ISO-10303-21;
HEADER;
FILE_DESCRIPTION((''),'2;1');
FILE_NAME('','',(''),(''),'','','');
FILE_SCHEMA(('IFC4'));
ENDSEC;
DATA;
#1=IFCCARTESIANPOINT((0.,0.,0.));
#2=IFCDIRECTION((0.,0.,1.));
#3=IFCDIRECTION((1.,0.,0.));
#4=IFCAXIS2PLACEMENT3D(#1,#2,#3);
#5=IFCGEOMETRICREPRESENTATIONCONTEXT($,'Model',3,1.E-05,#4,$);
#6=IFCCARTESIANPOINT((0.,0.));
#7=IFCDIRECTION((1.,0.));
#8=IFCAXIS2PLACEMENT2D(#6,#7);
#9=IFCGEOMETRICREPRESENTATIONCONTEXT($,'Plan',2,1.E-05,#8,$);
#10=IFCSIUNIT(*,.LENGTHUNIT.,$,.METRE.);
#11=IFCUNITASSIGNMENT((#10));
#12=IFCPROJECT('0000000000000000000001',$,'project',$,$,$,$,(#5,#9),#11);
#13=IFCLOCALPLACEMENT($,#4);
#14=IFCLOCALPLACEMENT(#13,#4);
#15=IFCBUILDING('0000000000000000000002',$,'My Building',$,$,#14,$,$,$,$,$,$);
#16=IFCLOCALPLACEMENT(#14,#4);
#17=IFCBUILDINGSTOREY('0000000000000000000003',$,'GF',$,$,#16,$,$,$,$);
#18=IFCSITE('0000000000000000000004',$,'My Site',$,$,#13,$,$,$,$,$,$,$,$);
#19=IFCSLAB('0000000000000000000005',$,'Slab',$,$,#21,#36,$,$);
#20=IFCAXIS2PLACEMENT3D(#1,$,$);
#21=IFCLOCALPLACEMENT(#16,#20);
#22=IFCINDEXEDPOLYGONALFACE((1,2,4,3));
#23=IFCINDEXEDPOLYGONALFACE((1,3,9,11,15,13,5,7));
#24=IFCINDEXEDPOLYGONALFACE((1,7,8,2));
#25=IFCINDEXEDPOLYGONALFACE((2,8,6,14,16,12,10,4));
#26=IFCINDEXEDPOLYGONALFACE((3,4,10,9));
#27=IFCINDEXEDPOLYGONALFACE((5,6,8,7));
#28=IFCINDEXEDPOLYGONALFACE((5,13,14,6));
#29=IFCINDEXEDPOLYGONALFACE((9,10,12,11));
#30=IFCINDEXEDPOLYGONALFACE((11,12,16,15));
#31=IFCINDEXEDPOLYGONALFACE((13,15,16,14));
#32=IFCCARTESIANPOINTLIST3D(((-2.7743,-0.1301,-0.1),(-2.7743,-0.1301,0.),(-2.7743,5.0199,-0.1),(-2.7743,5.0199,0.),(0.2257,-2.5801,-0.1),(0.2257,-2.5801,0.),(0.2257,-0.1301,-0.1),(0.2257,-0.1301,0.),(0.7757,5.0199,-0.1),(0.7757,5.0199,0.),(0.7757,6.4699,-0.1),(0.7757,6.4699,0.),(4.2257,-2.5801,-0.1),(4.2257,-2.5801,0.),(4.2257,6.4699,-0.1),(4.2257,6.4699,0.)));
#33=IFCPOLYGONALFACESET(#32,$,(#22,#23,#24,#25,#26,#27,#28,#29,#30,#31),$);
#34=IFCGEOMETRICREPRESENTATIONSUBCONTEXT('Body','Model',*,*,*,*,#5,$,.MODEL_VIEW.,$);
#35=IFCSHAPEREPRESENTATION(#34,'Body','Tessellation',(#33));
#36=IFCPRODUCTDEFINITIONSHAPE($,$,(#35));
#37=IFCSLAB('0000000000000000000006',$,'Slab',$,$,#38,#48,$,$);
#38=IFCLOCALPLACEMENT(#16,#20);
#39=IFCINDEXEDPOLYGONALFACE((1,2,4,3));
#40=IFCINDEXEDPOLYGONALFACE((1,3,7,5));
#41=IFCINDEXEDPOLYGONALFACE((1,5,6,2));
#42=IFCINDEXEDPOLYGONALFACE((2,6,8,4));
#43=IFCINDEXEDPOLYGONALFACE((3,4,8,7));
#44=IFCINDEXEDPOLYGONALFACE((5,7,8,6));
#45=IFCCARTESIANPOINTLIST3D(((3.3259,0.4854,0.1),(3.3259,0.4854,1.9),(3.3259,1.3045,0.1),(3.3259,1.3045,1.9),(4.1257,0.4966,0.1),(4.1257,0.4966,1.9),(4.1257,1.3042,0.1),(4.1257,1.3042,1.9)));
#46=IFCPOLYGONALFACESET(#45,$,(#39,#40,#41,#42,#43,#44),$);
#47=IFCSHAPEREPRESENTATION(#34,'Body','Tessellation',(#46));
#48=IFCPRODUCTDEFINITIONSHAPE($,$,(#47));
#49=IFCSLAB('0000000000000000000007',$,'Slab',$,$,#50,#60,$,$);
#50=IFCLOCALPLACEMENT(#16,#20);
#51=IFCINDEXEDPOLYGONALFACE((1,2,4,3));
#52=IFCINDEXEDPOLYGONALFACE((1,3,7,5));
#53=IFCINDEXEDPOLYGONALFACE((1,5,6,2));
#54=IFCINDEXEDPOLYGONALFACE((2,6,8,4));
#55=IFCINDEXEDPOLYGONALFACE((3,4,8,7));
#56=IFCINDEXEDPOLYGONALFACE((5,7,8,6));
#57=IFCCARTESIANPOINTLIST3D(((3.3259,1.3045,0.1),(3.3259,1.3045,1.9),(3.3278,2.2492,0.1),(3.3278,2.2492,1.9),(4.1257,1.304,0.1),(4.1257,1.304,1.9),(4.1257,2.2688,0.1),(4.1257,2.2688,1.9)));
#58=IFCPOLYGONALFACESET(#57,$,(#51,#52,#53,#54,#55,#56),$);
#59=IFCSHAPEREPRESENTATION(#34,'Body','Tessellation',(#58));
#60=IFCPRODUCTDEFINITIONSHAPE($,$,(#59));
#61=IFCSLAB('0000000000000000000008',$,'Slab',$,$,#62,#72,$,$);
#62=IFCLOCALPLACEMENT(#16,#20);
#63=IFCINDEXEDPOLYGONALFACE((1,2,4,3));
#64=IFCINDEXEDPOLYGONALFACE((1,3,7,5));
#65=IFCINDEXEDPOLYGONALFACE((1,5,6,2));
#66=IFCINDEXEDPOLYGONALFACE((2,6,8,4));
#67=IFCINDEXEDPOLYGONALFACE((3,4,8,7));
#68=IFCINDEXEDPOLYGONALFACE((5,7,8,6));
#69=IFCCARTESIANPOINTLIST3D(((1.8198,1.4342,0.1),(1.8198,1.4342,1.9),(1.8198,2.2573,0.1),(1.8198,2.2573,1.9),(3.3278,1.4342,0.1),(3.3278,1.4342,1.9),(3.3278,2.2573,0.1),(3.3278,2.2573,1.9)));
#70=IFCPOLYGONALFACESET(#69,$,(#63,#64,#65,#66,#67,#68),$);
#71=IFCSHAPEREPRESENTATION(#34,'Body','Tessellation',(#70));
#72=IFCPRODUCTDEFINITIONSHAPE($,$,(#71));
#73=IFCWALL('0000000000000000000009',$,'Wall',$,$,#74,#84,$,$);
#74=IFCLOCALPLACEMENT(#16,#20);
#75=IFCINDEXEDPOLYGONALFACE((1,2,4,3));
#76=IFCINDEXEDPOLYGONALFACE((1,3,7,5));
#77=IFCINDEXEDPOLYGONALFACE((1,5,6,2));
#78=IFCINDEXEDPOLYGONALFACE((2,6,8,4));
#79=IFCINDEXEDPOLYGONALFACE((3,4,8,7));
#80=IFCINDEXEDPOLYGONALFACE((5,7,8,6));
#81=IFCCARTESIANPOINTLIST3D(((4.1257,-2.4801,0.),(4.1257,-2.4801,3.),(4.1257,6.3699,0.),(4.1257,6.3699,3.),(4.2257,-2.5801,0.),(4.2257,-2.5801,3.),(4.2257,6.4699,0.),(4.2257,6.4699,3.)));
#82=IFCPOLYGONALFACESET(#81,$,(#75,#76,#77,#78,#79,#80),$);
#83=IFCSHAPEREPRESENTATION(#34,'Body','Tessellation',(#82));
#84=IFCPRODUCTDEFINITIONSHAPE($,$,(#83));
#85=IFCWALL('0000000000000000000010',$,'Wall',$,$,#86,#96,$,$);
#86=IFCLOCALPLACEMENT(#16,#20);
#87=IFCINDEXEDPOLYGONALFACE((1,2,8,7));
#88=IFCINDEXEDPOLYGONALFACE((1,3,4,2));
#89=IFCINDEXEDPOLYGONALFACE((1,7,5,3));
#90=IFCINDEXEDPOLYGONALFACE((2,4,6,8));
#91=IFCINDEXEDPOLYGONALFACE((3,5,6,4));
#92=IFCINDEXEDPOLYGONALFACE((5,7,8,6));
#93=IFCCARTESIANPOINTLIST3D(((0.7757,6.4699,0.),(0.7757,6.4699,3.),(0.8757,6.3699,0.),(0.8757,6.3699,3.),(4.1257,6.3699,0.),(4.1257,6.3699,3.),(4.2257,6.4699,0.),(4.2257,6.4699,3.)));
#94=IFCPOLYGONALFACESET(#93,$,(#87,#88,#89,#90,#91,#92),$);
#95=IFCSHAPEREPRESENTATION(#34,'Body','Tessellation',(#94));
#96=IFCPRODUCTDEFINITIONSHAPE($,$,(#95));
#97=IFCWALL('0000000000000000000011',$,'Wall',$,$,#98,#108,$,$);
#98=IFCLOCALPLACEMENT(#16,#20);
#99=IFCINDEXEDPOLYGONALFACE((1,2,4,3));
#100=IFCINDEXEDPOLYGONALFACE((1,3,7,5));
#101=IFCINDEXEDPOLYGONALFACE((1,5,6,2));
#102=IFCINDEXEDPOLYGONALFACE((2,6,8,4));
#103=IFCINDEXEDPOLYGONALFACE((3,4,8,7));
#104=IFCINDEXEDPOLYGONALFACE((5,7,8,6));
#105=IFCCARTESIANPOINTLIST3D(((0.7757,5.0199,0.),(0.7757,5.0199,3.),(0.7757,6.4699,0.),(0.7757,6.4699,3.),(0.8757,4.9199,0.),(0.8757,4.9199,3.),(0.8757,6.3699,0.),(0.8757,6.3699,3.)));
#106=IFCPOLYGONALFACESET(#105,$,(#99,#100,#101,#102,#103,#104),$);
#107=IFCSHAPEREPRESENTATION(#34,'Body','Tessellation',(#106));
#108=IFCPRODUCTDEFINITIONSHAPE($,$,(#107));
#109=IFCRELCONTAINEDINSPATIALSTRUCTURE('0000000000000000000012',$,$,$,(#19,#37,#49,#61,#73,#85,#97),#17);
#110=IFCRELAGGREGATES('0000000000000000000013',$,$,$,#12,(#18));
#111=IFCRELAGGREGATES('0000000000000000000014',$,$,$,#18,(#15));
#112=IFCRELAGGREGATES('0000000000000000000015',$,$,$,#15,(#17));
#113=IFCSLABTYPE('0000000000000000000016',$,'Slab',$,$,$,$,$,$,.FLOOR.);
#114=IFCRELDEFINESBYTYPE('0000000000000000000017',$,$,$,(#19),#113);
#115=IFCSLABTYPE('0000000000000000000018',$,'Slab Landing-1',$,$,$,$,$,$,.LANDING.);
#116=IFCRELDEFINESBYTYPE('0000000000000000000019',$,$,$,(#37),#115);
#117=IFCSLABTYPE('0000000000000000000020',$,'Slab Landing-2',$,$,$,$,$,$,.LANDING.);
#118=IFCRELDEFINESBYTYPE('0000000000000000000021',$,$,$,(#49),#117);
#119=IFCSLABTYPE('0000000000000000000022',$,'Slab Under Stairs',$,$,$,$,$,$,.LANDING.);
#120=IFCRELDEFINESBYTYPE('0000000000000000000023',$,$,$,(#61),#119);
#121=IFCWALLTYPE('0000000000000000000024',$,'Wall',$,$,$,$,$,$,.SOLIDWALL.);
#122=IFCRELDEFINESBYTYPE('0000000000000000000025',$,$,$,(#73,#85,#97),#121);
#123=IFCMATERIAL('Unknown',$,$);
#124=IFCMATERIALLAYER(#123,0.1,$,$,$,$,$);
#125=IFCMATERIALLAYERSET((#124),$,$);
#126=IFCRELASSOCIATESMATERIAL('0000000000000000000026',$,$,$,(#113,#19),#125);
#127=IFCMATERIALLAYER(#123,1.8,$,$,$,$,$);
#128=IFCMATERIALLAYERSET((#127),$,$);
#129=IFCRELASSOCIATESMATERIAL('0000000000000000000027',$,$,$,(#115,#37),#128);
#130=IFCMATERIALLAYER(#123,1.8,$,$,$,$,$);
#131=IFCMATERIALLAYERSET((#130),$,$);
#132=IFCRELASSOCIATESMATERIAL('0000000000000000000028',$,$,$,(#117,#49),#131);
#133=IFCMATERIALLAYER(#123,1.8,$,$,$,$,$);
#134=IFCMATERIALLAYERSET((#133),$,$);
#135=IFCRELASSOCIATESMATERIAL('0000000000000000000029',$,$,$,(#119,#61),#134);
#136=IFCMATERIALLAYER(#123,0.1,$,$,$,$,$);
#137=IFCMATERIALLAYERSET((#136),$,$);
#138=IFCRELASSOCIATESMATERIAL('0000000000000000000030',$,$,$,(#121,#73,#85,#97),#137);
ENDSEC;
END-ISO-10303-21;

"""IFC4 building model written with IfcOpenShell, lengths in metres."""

from ifc_helpers import new_model, si_unit, frame, origin_with_axes, origin_2d_with_axis, place, context, subcontext, project, spatial, line, indexed_curve, outline, extrude, material, layer, layer_set, layer_usage, type_object, element, save


model = new_model("IFC4")

# Units and contexts
model_context = context("Model", 3, precision=1e-05, world=origin_with_axes())
plan_context = context("Plan", 2, precision=1e-05, world=origin_2d_with_axis())
body_context_1 = subcontext(model_context, "Body", "Model", "MODEL_VIEW")
ifc_project = project(units=[si_unit("LENGTHUNIT", "METRE")], contexts=[model_context, plan_context])

# Site, building, storey
site_placement = place(None, origin_with_axes())
site = spatial("IfcSite", under=ifc_project, at=site_placement, Name="My Site")
building_placement = place(site_placement, origin_with_axes())
building = spatial("IfcBuilding", under=site, at=building_placement, Name="My Building")
storey_placement = place(building_placement, origin_with_axes())
storey = spatial("IfcBuildingStorey", under=building, at=storey_placement, Name="GF")

# Slabs
ifc_material_1 = material(Name="Unknown")
ifc_layer_1 = layer(ifc_material_1, 0.1)
ifc_layer_set_1 = layer_set([ifc_layer_1])
ifc_layer_usage_1 = layer_usage(ifc_layer_set_1, "AXIS3", "POSITIVE", -0.1)
slab_type_1 = type_object("IfcSlabType", Name="Slab", PredefinedType="FLOOR", material=ifc_layer_set_1)
slab_1_placement = place(storey_placement, frame((4.2257, 6.4699, 0.0), z_axis=(0.0, 0.0, 1.0), x_axis=(1.0, 0.0, 0.0)))
element("IfcSlab", 1, at=slab_1_placement, inside=storey, type_object=slab_type_1, material=ifc_layer_usage_1, Name="Slab", context=body_context_1, shape_type="SweptSolid", body=[
    extrude(outline(indexed_curve([(0.0, 0.0), (-3.45, 0.0), (-3.45, -1.45), (-7.0, -1.45), (-7.0, -6.6), (-4.0, -6.6), (-4.0, -9.05), (0.0, -9.05), (0.0, 0.0)])), frame((0.0, 0.0, -0.1), z_axis=(0.0, 0.0, 1.0), x_axis=(1.0, 0.0, 0.0)), (0.0, 0.0, 1.0), 0.1),
])
ifc_layer_2 = layer(ifc_material_1, 1.8)
ifc_layer_set_2 = layer_set([ifc_layer_2])
ifc_layer_usage_2 = layer_usage(ifc_layer_set_2, "AXIS3", "POSITIVE", -0.1)
slab_type_2 = type_object("IfcSlabType", Name="Slab Landing-1", PredefinedType="LANDING", material=ifc_layer_set_2)
slab_2_placement = place(storey_placement, frame((3.3259, 1.3043, 0.2), z_axis=(0.0, 0.0, 1.0), x_axis=(1.0, 0.0, 0.0)))
element("IfcSlab", 2, at=slab_2_placement, inside=storey, type_object=slab_type_2, material=ifc_layer_usage_2, Name="Slab", context=body_context_1, shape_type="SweptSolid", body=[
    extrude(outline(indexed_curve([(0.7998, -0.0001), (0.7998, -0.8077), (0.0, -0.8189), (0.0, 0.0002), (0.7998, -0.0001)])), frame((0.0, 0.0, -0.1), z_axis=(0.0, 0.0, 1.0), x_axis=(1.0, 0.0, 0.0)), (0.0, 0.0, 1.0), 1.8),
])
ifc_layer_3 = layer(ifc_material_1, 1.8)
ifc_layer_set_3 = layer_set([ifc_layer_3])
ifc_layer_usage_3 = layer_usage(ifc_layer_set_3, "AXIS3", "POSITIVE", -1.8)
slab_type_3 = type_object("IfcSlabType", Name="Slab Landing-2", PredefinedType="LANDING", material=ifc_layer_set_3)
slab_3_placement = place(storey_placement, frame((3.3278, 1.3045, 1.9), z_axis=(0.0, 0.0, 1.0), x_axis=(1.0, 0.0, 0.0)))
element("IfcSlab", 3, at=slab_3_placement, inside=storey, type_object=slab_type_3, material=ifc_layer_usage_3, Name="Slab", context=body_context_1, shape_type="SweptSolid", body=[
    extrude(outline(indexed_curve([(-0.0018, 0.0), (0.0, 0.9447), (0.798, 0.9643), (0.798, -0.0005), (-0.0018, 0.0)])), frame((0.0, 0.0, -1.8), z_axis=(0.0, 0.0, 1.0), x_axis=(1.0, 0.0, 0.0)), (0.0, 0.0, 1.0), 1.8),
])
ifc_layer_4 = layer(ifc_material_1, 1.8)
ifc_layer_set_4 = layer_set([ifc_layer_4])
ifc_layer_usage_4 = layer_usage(ifc_layer_set_4, "AXIS3", "POSITIVE", -1.8)
slab_type_4 = type_object("IfcSlabType", Name="Slab Under Stairs", PredefinedType="LANDING", material=ifc_layer_set_4)
slab_4_placement = place(storey_placement, frame((3.3278, 2.2573, 1.9), z_axis=(0.0, 0.0, 1.0), x_axis=(1.0, 0.0, 0.0)))
element("IfcSlab", 4, at=slab_4_placement, inside=storey, type_object=slab_type_4, material=ifc_layer_usage_4, Name="Slab", context=body_context_1, shape_type="SweptSolid", body=[
    extrude(outline(indexed_curve([(0.0, 0.0), (0.0, -0.8231), (-1.5079, -0.8231), (-1.5079, 0.0), (0.0, 0.0)])), frame((0.0, 0.0, -1.8), z_axis=(0.0, 0.0, 1.0), x_axis=(1.0, 0.0, 0.0)), (0.0, 0.0, 1.0), 1.8),
])

# Shared definitions
ifc_layer_5 = layer(ifc_material_1, 0.1)
ifc_layer_set_5 = layer_set([ifc_layer_5])
wall_type = type_object("IfcWallType", Name="Wall", PredefinedType="SOLIDWALL", material=ifc_layer_set_5)

# Walls
ifc_layer_usage_5 = layer_usage(ifc_layer_set_5, "AXIS2", "POSITIVE", 0.0)
wall_1_placement = place(storey_placement, frame((4.2257, -2.5801, 0.0), z_axis=(0.0, 0.0, 1.0), x_axis=(0.0, 1.0, 0.0)))
element("IfcWall", 5, at=wall_1_placement, inside=storey, type_object=wall_type, material=ifc_layer_usage_5, Name="Wall", context=body_context_1, shape_type="SweptSolid", body=[
    extrude(outline(indexed_curve([(0.0, 0.0), (0.1, 0.1), (8.95, 0.1), (9.05, 0.0)], segments=[line(1, 2, 3, 4, 1)])), origin_with_axes(), (0.0, 0.0, 1.0), 3.0),
])
ifc_layer_usage_6 = layer_usage(ifc_layer_set_5, "AXIS2", "POSITIVE", 0.0)
wall_2_placement = place(storey_placement, frame((4.2257, 6.4699, 0.0), z_axis=(0.0, 0.0, 1.0), x_axis=(-1.0, 0.0, 0.0)))
element("IfcWall", 6, at=wall_2_placement, inside=storey, type_object=wall_type, material=ifc_layer_usage_6, Name="Wall", context=body_context_1, shape_type="SweptSolid", body=[
    extrude(outline(indexed_curve([(0.0, 0.0), (0.1, 0.1), (3.35, 0.1), (3.45, 0.0)], segments=[line(1, 2, 3, 4, 1)])), origin_with_axes(), (0.0, 0.0, 1.0), 3.0),
])
ifc_layer_usage_7 = layer_usage(ifc_layer_set_5, "AXIS2", "POSITIVE", 0.0)
wall_3_placement = place(storey_placement, frame((0.7757, 6.4699, 0.0), z_axis=(0.0, 0.0, 1.0), x_axis=(0.0, -1.0, 0.0)))
element("IfcWall", 7, at=wall_3_placement, inside=storey, type_object=wall_type, material=ifc_layer_usage_7, Name="Wall", context=body_context_1, shape_type="SweptSolid", body=[
    extrude(outline(indexed_curve([(0.0, 0.0), (0.1, 0.1), (1.55, 0.1), (1.45, 0.0)], segments=[line(1, 2, 3, 4, 1)])), origin_with_axes(), (0.0, 0.0, 1.0), 3.0),
])

save(model, "model.ifc")
